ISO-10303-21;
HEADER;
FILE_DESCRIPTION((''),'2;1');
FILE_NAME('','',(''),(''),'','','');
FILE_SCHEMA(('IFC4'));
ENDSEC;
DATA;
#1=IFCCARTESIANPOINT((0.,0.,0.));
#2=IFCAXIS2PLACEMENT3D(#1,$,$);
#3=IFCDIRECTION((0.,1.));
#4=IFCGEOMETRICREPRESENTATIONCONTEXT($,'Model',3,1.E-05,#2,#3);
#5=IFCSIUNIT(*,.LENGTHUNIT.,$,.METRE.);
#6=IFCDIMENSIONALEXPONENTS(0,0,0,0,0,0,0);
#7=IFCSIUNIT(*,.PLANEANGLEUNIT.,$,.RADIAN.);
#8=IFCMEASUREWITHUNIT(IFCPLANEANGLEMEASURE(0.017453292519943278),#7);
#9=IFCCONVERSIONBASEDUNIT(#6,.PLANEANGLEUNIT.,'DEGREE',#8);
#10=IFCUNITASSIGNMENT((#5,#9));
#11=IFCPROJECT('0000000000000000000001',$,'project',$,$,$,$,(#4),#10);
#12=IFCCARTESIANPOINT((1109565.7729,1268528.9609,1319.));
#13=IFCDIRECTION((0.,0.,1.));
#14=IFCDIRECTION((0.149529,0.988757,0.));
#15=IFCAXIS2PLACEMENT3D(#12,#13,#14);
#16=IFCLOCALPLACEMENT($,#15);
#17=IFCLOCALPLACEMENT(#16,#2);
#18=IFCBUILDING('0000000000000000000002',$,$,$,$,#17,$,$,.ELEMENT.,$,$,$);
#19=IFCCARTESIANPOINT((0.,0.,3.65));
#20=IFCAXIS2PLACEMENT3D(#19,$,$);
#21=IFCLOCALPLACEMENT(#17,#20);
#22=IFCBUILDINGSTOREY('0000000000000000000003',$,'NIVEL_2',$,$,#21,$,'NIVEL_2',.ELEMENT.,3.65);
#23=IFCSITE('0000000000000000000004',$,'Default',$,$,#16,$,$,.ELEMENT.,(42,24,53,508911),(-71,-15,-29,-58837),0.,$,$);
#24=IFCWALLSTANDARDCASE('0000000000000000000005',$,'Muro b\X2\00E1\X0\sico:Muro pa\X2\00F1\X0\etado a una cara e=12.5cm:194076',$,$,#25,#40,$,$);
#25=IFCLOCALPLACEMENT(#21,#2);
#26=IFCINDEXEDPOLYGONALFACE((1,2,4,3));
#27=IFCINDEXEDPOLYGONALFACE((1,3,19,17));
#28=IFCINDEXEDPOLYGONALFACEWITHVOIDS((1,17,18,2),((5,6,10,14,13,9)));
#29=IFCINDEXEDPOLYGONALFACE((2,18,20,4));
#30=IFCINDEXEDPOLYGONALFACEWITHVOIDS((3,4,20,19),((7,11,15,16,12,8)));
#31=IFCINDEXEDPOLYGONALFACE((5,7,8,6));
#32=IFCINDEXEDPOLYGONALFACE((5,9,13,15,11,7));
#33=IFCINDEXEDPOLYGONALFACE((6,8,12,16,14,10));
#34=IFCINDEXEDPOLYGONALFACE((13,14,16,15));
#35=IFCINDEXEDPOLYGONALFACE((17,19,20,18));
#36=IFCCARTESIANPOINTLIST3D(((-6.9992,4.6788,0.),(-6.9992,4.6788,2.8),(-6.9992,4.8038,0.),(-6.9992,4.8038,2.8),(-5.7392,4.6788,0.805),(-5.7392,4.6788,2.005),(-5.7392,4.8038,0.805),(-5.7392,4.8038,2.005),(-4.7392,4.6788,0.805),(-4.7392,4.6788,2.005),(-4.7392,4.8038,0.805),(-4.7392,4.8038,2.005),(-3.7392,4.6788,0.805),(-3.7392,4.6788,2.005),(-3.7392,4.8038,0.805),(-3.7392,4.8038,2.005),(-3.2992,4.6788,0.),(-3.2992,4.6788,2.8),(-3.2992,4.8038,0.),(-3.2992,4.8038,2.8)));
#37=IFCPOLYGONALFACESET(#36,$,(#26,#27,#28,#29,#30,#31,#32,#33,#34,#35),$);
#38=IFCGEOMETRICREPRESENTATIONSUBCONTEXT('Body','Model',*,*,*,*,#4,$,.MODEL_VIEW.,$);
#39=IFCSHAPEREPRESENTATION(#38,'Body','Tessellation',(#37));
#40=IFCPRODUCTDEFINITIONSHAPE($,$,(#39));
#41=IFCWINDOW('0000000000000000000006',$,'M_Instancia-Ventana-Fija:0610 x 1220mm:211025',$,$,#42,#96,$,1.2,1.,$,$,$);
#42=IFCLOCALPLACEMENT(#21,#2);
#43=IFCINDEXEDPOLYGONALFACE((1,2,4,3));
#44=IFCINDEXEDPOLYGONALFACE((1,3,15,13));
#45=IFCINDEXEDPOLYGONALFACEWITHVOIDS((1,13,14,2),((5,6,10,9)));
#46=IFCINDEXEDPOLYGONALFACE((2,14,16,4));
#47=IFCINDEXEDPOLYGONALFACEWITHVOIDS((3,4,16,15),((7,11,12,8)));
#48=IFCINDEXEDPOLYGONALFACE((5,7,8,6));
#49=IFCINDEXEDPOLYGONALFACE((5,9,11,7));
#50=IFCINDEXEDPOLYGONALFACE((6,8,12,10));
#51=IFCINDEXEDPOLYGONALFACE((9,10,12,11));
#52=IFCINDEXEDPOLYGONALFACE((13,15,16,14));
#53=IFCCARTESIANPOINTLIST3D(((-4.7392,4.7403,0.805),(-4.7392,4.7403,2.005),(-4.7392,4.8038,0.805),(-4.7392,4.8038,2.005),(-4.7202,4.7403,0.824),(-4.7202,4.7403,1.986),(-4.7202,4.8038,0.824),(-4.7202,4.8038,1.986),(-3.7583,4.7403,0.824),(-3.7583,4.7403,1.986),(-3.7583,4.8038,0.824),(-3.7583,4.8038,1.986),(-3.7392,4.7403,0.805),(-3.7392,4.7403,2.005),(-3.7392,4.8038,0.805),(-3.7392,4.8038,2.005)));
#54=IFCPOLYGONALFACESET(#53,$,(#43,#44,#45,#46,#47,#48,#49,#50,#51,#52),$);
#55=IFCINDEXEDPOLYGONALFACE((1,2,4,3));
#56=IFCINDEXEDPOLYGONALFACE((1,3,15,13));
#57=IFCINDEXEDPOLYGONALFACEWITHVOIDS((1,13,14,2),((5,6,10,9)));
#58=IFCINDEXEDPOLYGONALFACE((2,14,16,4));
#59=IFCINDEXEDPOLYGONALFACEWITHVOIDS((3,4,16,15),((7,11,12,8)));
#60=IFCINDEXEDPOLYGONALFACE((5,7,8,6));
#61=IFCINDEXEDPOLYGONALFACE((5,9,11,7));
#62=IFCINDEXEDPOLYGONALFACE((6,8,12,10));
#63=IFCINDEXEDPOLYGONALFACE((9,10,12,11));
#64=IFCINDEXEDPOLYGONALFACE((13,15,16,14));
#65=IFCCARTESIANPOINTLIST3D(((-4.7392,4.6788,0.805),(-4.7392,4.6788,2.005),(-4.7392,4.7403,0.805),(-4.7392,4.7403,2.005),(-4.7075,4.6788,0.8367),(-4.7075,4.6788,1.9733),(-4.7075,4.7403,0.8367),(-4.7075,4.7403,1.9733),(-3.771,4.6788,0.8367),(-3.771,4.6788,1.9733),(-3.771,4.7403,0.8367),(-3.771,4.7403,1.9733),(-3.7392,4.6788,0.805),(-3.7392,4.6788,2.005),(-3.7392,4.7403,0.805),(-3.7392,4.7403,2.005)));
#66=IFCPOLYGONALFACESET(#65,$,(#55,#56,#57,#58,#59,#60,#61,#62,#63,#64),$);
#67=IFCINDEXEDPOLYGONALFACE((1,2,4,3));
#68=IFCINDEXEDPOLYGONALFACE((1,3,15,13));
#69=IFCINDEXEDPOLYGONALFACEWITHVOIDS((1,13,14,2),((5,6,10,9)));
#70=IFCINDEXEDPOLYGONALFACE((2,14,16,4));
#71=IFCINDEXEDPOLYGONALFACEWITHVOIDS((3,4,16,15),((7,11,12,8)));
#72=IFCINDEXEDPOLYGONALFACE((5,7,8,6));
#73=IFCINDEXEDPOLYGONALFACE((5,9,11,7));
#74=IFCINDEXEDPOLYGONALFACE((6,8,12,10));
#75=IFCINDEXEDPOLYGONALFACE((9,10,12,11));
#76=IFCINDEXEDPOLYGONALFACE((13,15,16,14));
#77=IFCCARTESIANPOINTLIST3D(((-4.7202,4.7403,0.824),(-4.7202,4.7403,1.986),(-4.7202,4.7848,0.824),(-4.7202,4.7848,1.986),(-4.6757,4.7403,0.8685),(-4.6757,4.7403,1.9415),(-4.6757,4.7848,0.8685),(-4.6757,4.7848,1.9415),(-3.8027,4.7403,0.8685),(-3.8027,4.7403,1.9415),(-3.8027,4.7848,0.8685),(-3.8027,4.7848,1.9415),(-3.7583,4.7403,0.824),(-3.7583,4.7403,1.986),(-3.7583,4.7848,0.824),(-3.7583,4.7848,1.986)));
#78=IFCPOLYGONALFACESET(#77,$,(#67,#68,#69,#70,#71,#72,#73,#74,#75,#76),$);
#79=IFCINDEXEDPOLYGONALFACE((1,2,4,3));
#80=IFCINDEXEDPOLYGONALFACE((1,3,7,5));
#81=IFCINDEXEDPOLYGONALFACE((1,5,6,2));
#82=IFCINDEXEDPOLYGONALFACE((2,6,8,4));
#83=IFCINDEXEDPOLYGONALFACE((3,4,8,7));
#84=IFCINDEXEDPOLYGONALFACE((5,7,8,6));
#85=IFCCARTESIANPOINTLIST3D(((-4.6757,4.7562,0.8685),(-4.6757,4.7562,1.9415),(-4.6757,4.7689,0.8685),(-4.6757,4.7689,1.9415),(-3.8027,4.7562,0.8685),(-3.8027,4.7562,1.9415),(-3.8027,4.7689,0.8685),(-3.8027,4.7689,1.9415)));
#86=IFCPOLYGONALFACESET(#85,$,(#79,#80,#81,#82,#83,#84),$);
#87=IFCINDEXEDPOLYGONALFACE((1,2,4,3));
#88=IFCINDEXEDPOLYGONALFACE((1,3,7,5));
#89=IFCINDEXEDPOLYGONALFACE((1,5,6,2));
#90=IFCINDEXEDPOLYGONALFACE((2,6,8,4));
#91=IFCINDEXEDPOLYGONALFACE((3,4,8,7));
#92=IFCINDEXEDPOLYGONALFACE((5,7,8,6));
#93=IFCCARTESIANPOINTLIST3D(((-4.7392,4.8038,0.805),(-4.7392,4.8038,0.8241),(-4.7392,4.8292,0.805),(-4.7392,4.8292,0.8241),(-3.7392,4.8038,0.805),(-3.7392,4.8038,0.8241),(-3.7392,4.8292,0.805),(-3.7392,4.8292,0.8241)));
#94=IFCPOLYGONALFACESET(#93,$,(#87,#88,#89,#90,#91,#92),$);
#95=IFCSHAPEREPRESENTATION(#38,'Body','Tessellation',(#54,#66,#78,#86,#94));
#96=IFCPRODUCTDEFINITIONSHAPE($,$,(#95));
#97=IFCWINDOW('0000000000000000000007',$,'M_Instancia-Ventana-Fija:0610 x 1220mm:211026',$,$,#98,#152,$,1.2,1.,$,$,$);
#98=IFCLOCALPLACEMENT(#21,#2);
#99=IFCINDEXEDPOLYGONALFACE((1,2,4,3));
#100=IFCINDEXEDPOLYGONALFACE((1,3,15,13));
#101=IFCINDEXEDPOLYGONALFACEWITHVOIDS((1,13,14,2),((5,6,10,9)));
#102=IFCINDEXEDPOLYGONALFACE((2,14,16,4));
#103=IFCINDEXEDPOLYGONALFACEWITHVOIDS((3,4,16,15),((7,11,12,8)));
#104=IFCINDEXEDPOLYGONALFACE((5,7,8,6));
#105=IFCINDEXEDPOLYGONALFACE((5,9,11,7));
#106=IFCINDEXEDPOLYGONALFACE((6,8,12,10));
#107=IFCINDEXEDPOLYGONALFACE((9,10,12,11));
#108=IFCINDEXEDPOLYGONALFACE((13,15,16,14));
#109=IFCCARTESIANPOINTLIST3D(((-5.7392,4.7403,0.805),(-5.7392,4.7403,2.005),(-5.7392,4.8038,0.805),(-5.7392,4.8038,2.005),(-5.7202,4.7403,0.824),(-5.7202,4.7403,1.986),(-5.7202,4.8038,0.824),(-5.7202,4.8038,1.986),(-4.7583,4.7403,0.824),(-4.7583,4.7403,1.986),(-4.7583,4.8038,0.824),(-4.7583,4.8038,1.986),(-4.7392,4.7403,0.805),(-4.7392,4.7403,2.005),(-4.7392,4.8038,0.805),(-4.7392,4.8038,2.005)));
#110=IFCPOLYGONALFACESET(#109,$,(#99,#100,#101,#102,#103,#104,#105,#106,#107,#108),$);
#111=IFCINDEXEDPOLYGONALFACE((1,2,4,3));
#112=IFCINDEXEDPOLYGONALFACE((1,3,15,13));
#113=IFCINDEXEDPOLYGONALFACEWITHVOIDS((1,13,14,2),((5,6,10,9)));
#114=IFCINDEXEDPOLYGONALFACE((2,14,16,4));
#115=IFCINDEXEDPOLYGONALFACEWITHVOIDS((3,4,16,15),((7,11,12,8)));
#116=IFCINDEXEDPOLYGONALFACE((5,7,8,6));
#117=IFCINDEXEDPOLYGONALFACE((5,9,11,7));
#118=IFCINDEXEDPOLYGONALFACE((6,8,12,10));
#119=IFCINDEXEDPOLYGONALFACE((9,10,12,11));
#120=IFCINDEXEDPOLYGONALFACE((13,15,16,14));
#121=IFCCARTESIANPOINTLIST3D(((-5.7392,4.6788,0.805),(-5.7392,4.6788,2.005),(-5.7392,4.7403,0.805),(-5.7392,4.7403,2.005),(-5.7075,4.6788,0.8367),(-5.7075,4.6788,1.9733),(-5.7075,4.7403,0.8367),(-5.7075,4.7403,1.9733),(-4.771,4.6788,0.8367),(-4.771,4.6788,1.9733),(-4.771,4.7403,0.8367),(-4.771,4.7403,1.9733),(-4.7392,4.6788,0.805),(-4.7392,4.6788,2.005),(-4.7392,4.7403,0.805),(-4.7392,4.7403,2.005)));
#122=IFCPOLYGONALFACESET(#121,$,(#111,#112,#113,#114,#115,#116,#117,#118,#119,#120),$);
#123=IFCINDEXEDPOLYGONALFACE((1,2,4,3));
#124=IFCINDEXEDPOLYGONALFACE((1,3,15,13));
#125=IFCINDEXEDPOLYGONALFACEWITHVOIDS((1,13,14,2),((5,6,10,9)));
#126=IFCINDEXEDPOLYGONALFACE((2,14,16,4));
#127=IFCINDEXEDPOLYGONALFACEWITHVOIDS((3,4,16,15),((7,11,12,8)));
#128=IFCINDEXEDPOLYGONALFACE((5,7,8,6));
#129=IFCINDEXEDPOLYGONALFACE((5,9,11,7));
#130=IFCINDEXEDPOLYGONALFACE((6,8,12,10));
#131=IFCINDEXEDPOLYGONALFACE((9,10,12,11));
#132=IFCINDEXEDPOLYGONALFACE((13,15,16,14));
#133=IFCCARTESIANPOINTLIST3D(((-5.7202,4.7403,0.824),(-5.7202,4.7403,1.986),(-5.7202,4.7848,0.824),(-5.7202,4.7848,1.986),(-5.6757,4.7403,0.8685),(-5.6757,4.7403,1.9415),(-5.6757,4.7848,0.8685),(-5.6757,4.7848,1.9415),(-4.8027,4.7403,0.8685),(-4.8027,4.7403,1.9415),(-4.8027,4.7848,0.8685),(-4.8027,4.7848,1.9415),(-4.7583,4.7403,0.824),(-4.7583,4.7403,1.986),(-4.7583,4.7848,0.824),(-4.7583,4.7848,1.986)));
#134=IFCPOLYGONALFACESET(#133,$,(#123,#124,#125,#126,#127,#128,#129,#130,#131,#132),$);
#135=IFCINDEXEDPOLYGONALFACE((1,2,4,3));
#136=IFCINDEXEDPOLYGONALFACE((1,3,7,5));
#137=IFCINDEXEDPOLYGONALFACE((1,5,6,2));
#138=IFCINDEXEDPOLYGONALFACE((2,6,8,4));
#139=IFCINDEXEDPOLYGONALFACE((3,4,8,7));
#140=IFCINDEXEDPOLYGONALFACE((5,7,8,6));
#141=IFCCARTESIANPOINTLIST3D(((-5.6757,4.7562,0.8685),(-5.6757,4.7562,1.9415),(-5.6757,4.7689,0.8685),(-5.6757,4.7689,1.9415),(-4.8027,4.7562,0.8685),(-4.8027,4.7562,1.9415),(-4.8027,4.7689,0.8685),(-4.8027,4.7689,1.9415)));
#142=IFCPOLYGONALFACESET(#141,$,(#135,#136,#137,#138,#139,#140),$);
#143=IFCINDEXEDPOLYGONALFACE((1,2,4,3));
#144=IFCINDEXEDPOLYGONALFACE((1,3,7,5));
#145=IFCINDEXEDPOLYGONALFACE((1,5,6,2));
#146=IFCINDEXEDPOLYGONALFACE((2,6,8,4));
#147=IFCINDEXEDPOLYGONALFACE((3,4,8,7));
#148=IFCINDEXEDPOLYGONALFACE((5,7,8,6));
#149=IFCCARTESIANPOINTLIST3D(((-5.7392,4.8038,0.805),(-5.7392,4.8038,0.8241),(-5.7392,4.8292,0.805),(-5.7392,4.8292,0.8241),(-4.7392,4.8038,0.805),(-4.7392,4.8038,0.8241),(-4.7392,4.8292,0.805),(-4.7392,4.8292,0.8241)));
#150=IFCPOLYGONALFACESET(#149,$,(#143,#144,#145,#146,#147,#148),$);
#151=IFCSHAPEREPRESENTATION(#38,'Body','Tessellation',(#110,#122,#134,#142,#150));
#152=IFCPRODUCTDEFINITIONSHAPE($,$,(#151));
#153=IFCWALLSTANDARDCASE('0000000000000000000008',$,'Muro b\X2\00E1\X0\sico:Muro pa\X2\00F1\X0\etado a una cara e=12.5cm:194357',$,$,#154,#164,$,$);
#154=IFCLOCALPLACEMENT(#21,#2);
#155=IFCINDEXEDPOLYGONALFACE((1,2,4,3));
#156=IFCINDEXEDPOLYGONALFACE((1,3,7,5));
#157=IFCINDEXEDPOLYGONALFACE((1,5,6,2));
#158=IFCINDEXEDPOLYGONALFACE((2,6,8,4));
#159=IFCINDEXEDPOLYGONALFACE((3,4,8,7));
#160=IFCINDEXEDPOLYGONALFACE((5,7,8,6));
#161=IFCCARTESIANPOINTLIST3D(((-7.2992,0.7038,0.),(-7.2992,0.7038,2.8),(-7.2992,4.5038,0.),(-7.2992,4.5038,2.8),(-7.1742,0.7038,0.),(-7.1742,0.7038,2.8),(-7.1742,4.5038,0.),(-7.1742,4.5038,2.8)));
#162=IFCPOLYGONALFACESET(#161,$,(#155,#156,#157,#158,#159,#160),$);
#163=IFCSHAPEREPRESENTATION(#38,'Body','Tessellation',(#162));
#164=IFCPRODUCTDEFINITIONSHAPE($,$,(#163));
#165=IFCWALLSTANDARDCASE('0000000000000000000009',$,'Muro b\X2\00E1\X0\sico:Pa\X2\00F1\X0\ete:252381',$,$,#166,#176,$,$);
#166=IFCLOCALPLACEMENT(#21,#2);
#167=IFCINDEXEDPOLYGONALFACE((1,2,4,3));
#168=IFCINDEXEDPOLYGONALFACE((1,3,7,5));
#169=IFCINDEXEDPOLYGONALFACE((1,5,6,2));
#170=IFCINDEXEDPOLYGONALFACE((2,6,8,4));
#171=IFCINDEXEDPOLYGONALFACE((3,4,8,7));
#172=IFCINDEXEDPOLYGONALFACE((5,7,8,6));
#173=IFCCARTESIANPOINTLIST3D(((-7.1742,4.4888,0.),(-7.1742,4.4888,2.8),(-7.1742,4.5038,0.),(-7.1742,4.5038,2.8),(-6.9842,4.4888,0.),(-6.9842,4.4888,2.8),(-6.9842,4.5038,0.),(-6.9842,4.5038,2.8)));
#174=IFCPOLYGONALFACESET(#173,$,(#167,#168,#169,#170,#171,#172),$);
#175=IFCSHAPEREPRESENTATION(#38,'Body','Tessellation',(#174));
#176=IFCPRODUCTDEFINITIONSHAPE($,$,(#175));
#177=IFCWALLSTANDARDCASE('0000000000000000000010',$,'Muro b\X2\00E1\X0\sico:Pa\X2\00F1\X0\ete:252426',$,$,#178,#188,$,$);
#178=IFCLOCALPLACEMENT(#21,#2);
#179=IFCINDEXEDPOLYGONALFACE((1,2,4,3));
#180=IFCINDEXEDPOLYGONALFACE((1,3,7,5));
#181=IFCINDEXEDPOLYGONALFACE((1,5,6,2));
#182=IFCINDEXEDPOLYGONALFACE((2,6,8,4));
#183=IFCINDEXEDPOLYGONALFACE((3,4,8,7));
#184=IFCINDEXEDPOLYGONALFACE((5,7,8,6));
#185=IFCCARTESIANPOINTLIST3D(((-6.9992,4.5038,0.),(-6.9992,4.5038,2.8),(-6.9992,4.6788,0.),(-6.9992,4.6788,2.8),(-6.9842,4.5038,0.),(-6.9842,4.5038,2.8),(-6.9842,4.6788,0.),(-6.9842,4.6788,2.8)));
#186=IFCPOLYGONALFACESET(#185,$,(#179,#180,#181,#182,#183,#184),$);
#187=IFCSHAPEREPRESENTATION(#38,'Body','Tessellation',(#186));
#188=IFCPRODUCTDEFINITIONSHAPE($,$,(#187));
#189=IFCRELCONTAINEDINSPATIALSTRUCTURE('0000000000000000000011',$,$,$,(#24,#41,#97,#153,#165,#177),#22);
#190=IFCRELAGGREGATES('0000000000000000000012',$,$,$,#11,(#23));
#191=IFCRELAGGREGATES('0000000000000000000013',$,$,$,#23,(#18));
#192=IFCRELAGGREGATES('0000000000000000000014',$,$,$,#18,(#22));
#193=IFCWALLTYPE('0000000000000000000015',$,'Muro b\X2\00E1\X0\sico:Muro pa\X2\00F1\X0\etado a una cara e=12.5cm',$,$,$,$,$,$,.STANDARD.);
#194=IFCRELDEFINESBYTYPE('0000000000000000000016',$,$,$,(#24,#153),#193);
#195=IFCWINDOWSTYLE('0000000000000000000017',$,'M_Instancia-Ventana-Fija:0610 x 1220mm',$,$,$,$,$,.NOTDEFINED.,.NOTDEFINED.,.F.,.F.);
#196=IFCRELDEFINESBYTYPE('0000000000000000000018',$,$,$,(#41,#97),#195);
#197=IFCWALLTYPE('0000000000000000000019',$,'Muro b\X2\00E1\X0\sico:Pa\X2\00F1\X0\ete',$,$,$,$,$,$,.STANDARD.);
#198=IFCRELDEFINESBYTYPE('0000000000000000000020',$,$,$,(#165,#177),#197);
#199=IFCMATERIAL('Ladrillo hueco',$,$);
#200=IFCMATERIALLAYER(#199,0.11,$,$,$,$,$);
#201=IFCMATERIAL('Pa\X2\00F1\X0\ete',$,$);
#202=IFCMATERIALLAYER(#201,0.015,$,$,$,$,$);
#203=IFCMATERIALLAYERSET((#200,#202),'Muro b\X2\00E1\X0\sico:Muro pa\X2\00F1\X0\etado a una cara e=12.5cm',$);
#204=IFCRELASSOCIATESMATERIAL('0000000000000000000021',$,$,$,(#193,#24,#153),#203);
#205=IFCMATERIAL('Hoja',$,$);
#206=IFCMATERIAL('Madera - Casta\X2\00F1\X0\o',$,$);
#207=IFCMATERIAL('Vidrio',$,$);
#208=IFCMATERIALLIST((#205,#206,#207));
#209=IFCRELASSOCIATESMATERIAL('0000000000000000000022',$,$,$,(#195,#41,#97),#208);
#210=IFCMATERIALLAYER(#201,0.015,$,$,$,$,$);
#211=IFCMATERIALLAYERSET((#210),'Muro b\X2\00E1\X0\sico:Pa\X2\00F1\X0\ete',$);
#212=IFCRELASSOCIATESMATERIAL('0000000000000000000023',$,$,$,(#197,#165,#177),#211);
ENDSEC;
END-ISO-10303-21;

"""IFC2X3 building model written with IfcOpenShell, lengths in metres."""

from ifc_helpers import new_model, entity, si_unit, converted_unit, direction, frame, frame_2d, origin, origin_2d_with_axis, place, context, subcontext, project, spatial, polyline, rectangle, outline, extrude, source, transform, mapped, material, material_list, layer, layer_set, layer_usage, type_object, type_shapes, element, fill, save


model = new_model("IFC2X3")

# Units and contexts
model_context = context("Model", 3, precision=1e-05, world=origin(), true_north=direction((0.0, 1.0)))
body_context = subcontext(model_context, "Body", "Model", "MODEL_VIEW")
ifc_project = project(units=[si_unit("LENGTHUNIT", "METRE"), converted_unit("PLANEANGLEUNIT", "DEGREE", entity("IfcPlaneAngleMeasure", 0.017453292519943278), si_unit("PLANEANGLEUNIT", "RADIAN"), dimensions=[0, 0, 0, 0, 0, 0, 0])], contexts=[model_context])

# Site, building, storey
site_placement = place(None, frame((1109565.7729, 1268528.9609, 1319.0), z_axis=(0.0, 0.0, 1.0), x_axis=(0.149529, 0.988757, 0.0)))
site = spatial("IfcSite", under=ifc_project, at=site_placement, Name="Default", CompositionType="ELEMENT", RefLatitude=(42, 24, 53, 508911), RefLongitude=(-71, -15, -29, -58837), RefElevation=0.0)
building_placement = place(site_placement, origin())
building = spatial("IfcBuilding", under=site, at=building_placement, CompositionType="ELEMENT")
storey_placement = place(building_placement, frame((0.0, 0.0, 3.65)))
storey = spatial("IfcBuildingStorey", under=building, at=storey_placement, Name="NIVEL_2", LongName="NIVEL_2", CompositionType="ELEMENT", Elevation=3.65)

# Wall, openings, windows
ifc_material_1 = material(Name="Ladrillo hueco")
ifc_layer_1 = layer(ifc_material_1, 0.11)
ifc_material_2 = material(Name="Pañete")
ifc_layer_2 = layer(ifc_material_2, 0.015)
ifc_layer_set_1 = layer_set([ifc_layer_1, ifc_layer_2], Name="Muro básico:Muro pañetado a una cara e=12.5cm")
ifc_layer_usage_1 = layer_usage(ifc_layer_set_1, "AXIS2", "NEGATIVE", 0.0625)
wall_type_1 = type_object("IfcWallType", Name="Muro básico:Muro pañetado a una cara e=12.5cm", PredefinedType="STANDARD", material=ifc_layer_set_1)
wall_1_placement = place(storey_placement, frame((-6.9992, 4.7413, 0.0)))
wall_1 = element("IfcWallStandardCase", 1, at=wall_1_placement, inside=storey, type_object=wall_type_1, material=ifc_layer_usage_1, Name="Muro básico:Muro pañetado a una cara e=12.5cm:194076", context=body_context, shape_type="SweptSolid", body=[
    extrude(rectangle(XDim=3.7, YDim=0.125, at=frame_2d((1.85, 0.0), x_axis=(-1.0, 0.0))), origin(), (0.0, 0.0, 1.0), 2.8),
])
opening_1_placement = place(wall_1_placement, frame((1.26, -0.0625, 0.805)))
opening_1 = element("IfcOpeningElement", 2, at=opening_1_placement, cuts=wall_1, ObjectType="Opening", context=body_context, shape_type="SweptSolid", body=[
    extrude(rectangle(XDim=1.2, YDim=1.0, at=frame_2d((0.6, 0.5), x_axis=(-1.0, 0.0))), frame((0.0, 0.0, 0.0), z_axis=(0.0, 1.0, 0.0), x_axis=(0.0, 0.0, 1.0)), (0.0, 0.0, 1.0), 0.125),
])
opening_2_placement = place(wall_1_placement, frame((2.26, -0.0625, 0.805)))
opening_2 = element("IfcOpeningElement", 3, at=opening_2_placement, cuts=wall_1, ObjectType="Opening", context=body_context, shape_type="SweptSolid", body=[
    extrude(rectangle(XDim=1.2, YDim=1.0, at=frame_2d((0.6, 0.5), x_axis=(-1.0, 0.0))), frame((0.0, 0.0, 0.0), z_axis=(0.0, 1.0, 0.0), x_axis=(0.0, 0.0, 1.0)), (0.0, 0.0, 1.0), 0.125),
])
ifc_material_3 = material(Name="Hoja")
ifc_material_4 = material(Name="Madera - Castaño")
ifc_material_5 = material(Name="Vidrio")
ifc_material_list = material_list([ifc_material_3, ifc_material_4, ifc_material_5])
window_style = type_object("IfcWindowStyle", Name="M_Instancia-Ventana-Fija:0610 x 1220mm", ConstructionType="NOTDEFINED", OperationType="NOTDEFINED", ParameterTakesPrecedence=False, Sizeable=False, material=ifc_material_list)
shared_shape = source(origin(), body_context, "Body", "SweptSolid", [
    extrude(outline(polyline([(-0.6, -0.5), (0.6, -0.5), (0.6, 0.5), (-0.6, 0.5), (-0.6, -0.5)]), holes=[polyline([(-0.5809, -0.4809), (-0.5809, 0.481), (0.581, 0.481), (0.581, -0.4809), (-0.5809, -0.4809)])]), frame((0.5, 0.0616, 0.6), z_axis=(0.0, 1.0, 0.0), x_axis=(0.0, 0.0, -1.0)), (0.0, 0.0, 1.0), 0.0635),
    extrude(outline(polyline([(-0.5, -0.6), (0.5, -0.6), (0.5, 0.6), (-0.5, 0.6), (-0.5, -0.6)]), holes=[polyline([(-0.4683, -0.5682), (-0.4683, 0.5683), (0.4682, 0.5683), (0.4682, -0.5682), (-0.4683, -0.5682)])]), frame((0.5, 0.0, 0.6), z_axis=(0.0, 1.0, 0.0), x_axis=(1.0, 0.0, 0.0)), (0.0, 0.0, 1.0), 0.0616),
    extrude(outline(polyline([(-0.4809, -0.581), (0.4809, -0.581), (0.4809, 0.581), (-0.4809, 0.581), (-0.4809, -0.581)]), holes=[polyline([(-0.4365, -0.5365), (-0.4365, 0.5365), (0.4365, 0.5365), (0.4365, -0.5365), (-0.4365, -0.5365)])]), frame((0.5, 0.0616, 0.6), z_axis=(0.0, 1.0, 0.0), x_axis=(1.0, 0.0, 0.0)), (0.0, 0.0, 1.0), 0.0444),
    extrude(rectangle(XDim=0.0127, YDim=0.873, at=origin_2d_with_axis()), frame((0.5, 0.0838, 0.0635), z_axis=(0.0, 0.0, 1.0), x_axis=(0.0, 1.0, 0.0)), (0.0, 0.0, 1.0), 1.073),
    extrude(rectangle(XDim=0.0254, YDim=1.0, at=origin_2d_with_axis()), frame((0.5, 0.1377, 0.0), z_axis=(0.0, 0.0, 1.0), x_axis=(0.0, -1.0, 0.0)), (0.0, 0.0, 1.0), 0.019),
])
type_shapes(window_style, [shared_shape])
window_1_placement = place(opening_2_placement, origin())
window_1 = element("IfcWindow", 4, at=window_1_placement, inside=storey, type_object=window_style, material=ifc_material_list, Name="M_Instancia-Ventana-Fija:0610 x 1220mm:211025", OverallHeight=1.2, OverallWidth=1.0, context=body_context, shape_type="MappedRepresentation", body=[
    mapped(shared_shape, transform((0.0, 0.0, 0.0), scale=1.0)),
])
fill(opening_2, window_1)
window_2_placement = place(opening_1_placement, origin())
window_2 = element("IfcWindow", 5, at=window_2_placement, inside=storey, type_object=window_style, material=ifc_material_list, Name="M_Instancia-Ventana-Fija:0610 x 1220mm:211026", OverallHeight=1.2, OverallWidth=1.0, context=body_context, shape_type="MappedRepresentation", body=[
    mapped(shared_shape, transform((0.0, 0.0, 0.0), scale=1.0)),
])
fill(opening_1, window_2)

# Walls
ifc_layer_usage_2 = layer_usage(ifc_layer_set_1, "AXIS2", "POSITIVE", -0.0625)
wall_2_placement = place(storey_placement, frame((-7.2367, 4.5038, 0.0), z_axis=(0.0, 0.0, 1.0), x_axis=(0.0, -1.0, 0.0)))
element("IfcWallStandardCase", 6, at=wall_2_placement, inside=storey, type_object=wall_type_1, material=ifc_layer_usage_2, Name="Muro básico:Muro pañetado a una cara e=12.5cm:194357", context=body_context, shape_type="SweptSolid", body=[
    extrude(rectangle(XDim=3.8, YDim=0.125, at=frame_2d((1.9, 0.0), x_axis=(-1.0, 0.0))), origin(), (0.0, 0.0, 1.0), 2.8),
])
ifc_layer_3 = layer(ifc_material_2, 0.015)
ifc_layer_set_2 = layer_set([ifc_layer_3], Name="Muro básico:Pañete")
ifc_layer_usage_3 = layer_usage(ifc_layer_set_2, "AXIS2", "POSITIVE", -0.0075)
wall_type_2 = type_object("IfcWallType", Name="Muro básico:Pañete", PredefinedType="STANDARD", material=ifc_layer_set_2)
wall_3_placement = place(storey_placement, frame((-7.1742, 4.4963, 0.0)))
element("IfcWallStandardCase", 7, at=wall_3_placement, inside=storey, type_object=wall_type_2, material=ifc_layer_usage_3, Name="Muro básico:Pañete:252381", context=body_context, shape_type="SweptSolid", body=[
    extrude(rectangle(XDim=0.19, YDim=0.015, at=frame_2d((0.095, 0.0), x_axis=(-1.0, 0.0))), origin(), (0.0, 0.0, 1.0), 2.8),
])
ifc_layer_usage_4 = layer_usage(ifc_layer_set_2, "AXIS2", "POSITIVE", -0.0075)
wall_4_placement = place(storey_placement, frame((-6.9917, 4.5038, 0.0), z_axis=(0.0, 0.0, 1.0), x_axis=(0.0, 1.0, 0.0)))
element("IfcWallStandardCase", 8, at=wall_4_placement, inside=storey, type_object=wall_type_2, material=ifc_layer_usage_4, Name="Muro básico:Pañete:252426", context=body_context, shape_type="SweptSolid", body=[
    extrude(rectangle(XDim=0.175, YDim=0.015, at=frame_2d((0.0875, 0.0), x_axis=(-1.0, 0.0))), origin(), (0.0, 0.0, 1.0), 2.8),
])

save(model, "model.ifc")
